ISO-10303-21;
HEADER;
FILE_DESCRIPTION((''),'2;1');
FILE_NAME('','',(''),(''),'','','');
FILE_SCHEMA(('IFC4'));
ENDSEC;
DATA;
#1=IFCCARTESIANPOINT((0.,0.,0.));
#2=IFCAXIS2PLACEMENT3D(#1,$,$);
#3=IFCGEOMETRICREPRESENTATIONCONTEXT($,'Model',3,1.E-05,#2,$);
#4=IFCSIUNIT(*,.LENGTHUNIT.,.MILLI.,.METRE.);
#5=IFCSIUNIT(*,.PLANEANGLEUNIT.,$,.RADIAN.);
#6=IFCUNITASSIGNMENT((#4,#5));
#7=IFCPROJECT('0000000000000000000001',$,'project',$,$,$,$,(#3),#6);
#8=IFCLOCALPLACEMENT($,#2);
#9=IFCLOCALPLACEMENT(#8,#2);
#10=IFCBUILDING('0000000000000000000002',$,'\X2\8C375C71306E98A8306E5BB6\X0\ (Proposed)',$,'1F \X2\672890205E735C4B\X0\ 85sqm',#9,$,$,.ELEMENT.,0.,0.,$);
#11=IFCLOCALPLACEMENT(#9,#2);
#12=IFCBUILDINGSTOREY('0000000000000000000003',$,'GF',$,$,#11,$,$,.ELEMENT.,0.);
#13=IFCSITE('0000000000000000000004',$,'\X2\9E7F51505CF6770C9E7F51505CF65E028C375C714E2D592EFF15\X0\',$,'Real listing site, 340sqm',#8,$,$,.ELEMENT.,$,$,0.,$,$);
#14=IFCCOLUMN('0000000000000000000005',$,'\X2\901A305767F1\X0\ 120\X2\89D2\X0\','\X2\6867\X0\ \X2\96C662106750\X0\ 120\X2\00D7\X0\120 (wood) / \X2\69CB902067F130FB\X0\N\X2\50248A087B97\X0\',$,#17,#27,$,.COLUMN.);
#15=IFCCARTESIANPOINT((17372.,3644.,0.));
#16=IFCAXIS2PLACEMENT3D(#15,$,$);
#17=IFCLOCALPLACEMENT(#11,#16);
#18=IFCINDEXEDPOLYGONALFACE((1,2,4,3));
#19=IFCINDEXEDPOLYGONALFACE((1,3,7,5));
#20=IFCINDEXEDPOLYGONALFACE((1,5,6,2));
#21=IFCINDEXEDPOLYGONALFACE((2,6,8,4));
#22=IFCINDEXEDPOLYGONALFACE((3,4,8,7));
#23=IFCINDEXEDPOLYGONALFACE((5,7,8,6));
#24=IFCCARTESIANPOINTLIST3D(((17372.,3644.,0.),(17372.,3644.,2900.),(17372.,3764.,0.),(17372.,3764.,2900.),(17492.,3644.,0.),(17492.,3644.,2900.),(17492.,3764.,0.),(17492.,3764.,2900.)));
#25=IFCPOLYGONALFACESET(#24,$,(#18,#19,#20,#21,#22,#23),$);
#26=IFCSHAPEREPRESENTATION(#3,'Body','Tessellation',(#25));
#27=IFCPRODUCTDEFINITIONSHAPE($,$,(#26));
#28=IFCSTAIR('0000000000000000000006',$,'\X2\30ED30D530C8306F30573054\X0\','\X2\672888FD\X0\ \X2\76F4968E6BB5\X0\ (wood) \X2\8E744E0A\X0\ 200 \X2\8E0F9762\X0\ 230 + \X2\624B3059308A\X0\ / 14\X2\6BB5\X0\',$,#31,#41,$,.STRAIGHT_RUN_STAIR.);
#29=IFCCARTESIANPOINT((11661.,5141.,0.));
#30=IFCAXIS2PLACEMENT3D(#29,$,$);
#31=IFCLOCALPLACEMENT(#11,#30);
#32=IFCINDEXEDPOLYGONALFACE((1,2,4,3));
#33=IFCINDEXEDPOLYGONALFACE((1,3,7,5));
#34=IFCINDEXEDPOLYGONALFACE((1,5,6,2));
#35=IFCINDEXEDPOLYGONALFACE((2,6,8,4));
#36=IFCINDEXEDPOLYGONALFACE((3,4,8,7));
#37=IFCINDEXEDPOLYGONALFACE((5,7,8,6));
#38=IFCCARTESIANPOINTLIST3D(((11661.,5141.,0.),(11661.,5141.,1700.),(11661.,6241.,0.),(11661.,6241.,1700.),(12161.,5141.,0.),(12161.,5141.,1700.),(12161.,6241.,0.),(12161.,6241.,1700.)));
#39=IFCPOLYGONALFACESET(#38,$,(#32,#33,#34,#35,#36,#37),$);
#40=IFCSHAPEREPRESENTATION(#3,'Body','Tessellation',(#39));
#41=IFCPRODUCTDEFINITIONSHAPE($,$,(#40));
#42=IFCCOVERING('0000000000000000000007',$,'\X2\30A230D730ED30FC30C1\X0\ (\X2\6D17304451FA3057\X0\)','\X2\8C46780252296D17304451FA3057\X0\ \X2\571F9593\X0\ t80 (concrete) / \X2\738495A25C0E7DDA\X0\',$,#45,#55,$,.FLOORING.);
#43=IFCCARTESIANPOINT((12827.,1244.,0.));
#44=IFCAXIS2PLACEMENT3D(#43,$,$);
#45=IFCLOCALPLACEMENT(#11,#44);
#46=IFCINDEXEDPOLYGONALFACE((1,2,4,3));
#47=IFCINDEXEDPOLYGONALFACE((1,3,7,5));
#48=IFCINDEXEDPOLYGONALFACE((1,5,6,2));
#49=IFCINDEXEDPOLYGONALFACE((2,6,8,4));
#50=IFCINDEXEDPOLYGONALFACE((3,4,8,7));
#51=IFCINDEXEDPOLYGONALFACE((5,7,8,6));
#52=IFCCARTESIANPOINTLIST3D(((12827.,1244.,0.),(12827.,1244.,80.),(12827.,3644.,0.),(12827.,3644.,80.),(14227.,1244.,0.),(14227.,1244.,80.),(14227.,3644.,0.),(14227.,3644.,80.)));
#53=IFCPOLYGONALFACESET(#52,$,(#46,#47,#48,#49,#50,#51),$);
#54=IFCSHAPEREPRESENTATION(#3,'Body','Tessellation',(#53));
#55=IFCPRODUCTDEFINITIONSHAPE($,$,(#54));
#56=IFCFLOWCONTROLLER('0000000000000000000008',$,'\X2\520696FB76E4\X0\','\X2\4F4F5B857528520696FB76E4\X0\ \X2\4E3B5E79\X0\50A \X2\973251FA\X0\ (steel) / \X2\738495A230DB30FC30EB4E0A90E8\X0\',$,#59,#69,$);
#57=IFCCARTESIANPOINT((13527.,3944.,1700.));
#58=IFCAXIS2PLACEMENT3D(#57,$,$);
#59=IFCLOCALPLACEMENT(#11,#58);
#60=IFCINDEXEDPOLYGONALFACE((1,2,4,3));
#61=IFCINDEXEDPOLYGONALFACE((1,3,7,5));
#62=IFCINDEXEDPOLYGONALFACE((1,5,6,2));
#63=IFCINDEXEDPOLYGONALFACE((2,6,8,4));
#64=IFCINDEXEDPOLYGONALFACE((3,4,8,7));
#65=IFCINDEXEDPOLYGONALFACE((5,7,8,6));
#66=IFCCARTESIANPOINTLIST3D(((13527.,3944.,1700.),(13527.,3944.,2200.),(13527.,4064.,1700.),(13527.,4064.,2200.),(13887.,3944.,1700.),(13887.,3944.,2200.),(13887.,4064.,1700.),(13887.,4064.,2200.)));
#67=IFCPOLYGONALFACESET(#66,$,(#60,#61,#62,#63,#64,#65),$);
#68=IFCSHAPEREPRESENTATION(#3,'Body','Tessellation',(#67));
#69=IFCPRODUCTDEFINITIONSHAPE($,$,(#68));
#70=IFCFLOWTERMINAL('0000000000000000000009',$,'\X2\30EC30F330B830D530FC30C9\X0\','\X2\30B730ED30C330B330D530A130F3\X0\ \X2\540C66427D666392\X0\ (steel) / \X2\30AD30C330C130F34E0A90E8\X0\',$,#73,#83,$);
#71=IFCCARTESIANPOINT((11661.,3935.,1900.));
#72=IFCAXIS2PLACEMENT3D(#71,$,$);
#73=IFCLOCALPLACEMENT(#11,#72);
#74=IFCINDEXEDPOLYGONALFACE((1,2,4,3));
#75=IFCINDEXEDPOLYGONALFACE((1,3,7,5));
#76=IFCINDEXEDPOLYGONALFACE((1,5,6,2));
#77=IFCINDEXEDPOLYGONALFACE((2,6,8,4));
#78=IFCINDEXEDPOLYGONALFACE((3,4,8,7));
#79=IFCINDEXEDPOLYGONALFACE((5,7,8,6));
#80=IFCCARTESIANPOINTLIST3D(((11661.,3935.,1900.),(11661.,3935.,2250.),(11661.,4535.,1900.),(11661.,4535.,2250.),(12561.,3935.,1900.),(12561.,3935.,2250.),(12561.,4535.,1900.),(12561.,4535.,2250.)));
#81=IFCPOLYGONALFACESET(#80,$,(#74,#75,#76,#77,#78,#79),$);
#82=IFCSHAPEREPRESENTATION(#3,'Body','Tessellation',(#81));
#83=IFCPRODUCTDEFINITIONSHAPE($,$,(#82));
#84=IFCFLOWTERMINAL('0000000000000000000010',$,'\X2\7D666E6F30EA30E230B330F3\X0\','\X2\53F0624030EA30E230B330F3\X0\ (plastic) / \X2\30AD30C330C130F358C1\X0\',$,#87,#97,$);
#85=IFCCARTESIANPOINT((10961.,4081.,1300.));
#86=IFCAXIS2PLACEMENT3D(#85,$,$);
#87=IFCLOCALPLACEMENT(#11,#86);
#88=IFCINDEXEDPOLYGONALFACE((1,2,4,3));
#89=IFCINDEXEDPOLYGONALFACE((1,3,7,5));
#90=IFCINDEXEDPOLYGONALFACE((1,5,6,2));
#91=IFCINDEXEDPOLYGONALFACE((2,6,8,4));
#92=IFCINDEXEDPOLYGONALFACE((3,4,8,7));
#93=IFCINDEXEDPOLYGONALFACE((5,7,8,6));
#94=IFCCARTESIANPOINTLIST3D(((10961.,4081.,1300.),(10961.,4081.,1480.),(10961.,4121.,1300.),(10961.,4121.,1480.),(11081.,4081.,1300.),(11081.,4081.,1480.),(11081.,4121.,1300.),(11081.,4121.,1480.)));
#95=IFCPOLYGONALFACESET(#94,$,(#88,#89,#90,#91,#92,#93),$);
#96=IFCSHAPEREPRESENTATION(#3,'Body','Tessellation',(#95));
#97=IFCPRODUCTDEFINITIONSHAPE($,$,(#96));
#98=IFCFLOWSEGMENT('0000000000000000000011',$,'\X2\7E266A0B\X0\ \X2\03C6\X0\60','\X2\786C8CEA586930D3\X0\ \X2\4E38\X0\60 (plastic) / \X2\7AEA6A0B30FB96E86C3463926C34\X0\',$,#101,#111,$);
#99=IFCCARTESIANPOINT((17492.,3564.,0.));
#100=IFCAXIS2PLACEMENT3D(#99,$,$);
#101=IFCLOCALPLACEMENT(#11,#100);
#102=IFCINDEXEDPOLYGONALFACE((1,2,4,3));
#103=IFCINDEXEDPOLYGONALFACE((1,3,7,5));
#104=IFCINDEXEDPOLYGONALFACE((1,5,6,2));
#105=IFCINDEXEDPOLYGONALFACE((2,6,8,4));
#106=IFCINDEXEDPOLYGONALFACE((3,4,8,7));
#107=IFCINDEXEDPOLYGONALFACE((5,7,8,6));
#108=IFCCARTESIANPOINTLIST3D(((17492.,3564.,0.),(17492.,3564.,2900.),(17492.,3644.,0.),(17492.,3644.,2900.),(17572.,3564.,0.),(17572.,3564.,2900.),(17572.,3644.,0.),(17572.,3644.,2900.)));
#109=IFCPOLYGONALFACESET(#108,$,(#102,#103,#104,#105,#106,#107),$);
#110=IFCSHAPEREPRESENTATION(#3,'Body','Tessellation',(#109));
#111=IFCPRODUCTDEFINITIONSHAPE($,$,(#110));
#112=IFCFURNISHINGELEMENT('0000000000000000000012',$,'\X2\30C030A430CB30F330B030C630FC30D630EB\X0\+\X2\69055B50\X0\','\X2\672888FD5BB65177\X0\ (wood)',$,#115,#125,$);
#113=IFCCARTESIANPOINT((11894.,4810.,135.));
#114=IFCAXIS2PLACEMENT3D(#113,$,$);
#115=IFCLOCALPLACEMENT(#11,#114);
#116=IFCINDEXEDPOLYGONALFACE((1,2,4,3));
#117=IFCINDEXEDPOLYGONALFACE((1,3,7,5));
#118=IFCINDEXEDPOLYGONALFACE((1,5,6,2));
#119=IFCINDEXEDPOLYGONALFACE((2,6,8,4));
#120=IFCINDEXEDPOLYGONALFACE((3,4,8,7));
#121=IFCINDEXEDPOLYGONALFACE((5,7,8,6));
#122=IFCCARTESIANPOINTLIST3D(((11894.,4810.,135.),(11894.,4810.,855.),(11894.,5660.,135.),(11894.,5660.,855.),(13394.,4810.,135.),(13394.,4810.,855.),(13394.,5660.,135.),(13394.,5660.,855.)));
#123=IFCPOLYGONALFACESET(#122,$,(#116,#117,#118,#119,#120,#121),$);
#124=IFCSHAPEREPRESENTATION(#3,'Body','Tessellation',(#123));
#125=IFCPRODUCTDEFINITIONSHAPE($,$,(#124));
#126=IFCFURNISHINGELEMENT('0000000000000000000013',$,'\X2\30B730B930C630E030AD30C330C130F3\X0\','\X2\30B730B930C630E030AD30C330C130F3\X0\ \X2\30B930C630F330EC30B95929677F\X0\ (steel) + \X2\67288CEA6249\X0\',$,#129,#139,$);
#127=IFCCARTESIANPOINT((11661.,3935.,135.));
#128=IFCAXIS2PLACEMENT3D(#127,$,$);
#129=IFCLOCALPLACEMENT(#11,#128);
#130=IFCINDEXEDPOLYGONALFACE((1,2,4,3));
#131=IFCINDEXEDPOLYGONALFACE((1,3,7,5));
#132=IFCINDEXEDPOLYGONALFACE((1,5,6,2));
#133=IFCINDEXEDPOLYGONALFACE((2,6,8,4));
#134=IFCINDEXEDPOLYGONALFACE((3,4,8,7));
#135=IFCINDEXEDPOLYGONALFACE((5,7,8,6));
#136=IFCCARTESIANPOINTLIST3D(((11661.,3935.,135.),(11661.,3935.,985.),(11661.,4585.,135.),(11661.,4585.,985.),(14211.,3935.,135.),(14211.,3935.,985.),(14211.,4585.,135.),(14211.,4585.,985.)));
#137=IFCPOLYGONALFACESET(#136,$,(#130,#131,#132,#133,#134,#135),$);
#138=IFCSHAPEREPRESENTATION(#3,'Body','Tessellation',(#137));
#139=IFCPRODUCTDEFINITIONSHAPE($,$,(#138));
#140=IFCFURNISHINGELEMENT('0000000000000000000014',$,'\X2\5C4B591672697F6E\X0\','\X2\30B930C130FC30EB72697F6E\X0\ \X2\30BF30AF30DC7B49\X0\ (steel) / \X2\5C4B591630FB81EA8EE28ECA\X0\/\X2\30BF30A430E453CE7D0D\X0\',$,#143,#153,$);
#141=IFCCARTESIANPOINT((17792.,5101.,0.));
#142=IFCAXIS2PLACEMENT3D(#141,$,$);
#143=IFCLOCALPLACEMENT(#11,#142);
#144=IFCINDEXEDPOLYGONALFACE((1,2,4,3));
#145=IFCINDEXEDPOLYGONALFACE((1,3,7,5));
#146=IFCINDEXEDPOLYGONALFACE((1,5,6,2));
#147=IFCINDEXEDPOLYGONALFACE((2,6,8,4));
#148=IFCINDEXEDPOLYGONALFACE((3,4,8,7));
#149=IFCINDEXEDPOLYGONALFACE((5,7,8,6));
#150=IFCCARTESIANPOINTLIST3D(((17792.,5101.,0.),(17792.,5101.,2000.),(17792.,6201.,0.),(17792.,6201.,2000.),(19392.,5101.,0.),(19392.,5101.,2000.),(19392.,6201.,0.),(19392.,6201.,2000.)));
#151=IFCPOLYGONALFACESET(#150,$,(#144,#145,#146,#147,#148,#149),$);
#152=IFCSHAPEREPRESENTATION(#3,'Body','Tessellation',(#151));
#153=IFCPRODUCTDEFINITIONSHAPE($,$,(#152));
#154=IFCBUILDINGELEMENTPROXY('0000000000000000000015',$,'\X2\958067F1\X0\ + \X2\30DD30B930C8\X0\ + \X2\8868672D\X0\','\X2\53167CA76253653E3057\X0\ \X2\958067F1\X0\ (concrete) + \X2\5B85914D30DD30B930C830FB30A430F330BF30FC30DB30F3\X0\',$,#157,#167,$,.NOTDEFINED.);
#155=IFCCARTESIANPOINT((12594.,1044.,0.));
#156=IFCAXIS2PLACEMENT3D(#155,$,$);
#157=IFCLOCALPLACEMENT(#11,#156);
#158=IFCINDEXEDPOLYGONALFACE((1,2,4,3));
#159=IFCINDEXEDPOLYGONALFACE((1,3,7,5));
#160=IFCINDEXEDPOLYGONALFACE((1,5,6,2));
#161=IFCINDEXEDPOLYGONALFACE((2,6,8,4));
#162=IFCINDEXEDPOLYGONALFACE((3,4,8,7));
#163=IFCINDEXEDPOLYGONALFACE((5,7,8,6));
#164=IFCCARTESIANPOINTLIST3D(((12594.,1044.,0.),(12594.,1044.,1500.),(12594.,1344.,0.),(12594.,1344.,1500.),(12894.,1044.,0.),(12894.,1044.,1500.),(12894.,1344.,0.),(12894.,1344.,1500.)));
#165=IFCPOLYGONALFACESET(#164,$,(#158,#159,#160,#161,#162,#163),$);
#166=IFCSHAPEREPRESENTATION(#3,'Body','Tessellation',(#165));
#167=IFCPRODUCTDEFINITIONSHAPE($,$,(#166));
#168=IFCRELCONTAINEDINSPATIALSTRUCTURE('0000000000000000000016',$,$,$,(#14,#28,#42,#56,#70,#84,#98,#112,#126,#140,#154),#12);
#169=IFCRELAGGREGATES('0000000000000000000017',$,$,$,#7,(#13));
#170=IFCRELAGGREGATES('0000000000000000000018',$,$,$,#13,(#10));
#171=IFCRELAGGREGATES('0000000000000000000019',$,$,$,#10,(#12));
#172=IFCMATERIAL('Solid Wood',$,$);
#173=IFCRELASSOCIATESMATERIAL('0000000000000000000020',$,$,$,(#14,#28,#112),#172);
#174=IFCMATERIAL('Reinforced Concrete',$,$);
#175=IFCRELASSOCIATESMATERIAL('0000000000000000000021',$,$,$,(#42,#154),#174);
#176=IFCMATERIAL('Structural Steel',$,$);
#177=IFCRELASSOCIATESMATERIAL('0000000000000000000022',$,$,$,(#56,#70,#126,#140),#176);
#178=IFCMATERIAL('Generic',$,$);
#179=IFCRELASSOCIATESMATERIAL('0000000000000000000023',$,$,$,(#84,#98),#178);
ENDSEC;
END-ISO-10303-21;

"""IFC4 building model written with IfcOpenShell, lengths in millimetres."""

from ifc_helpers import new_model, si_unit, frame, frame_2d, origin, place, context, project, spatial, rectangle, extrude, material, element, save


model = new_model("IFC4")

# Units and contexts
model_context = context("Model", 3, precision=1e-05, world=origin())
ifc_project = project(units=[si_unit("LENGTHUNIT", "METRE", prefix="MILLI"), si_unit("PLANEANGLEUNIT", "RADIAN")], contexts=[model_context])

# Site, building, storey
site_placement = place(None, origin())
site = spatial("IfcSite", under=ifc_project, at=site_placement, Name="鹿児島県鹿児島市谷山中央５", ObjectType="Real listing site, 340sqm", CompositionType="ELEMENT", RefElevation=0.0)
building_placement = place(site_placement, origin())
building = spatial("IfcBuilding", under=site, at=building_placement, Name="谷山の風の家 (Proposed)", ObjectType="1F 木造平屋 85sqm", CompositionType="ELEMENT", ElevationOfRefHeight=0.0, ElevationOfTerrain=0.0)
storey_placement = place(building_placement, origin())
storey = spatial("IfcBuildingStorey", under=building, at=storey_placement, Name="GF", CompositionType="ELEMENT", Elevation=0.0)

# Column
ifc_material_1 = material(Name="Solid Wood")
column_1_placement = place(storey_placement, frame((17372.0, 3644.0, 0.0)))
element("IfcColumn", 1, at=column_1_placement, inside=storey, material=ifc_material_1, Name="通し柱 120角", Description="桧 集成材 120×120 (wood) / 構造柱・N値計算", PredefinedType="COLUMN", context=model_context, shape_type="SweptSolid", body=[
    extrude(rectangle(XDim=120.0, YDim=120.0, at=frame_2d((60.0, 60.0))), frame((17372.0, 3644.0, 0.0)), (0.0, 0.0, 1.0), 2900.0),
])

# Stair
stair_placement = place(storey_placement, frame((11661.0, 5141.0, 0.0)))
element("IfcStair", 2, at=stair_placement, inside=storey, material=ifc_material_1, Name="ロフトはしご", Description="木製 直階段 (wood) 蹴上 200 踏面 230 + 手すり / 14段", PredefinedType="STRAIGHT_RUN_STAIR", context=model_context, shape_type="SweptSolid", body=[
    extrude(rectangle(XDim=500.0, YDim=1100.0, at=frame_2d((250.0, 550.0))), frame((11661.0, 5141.0, 0.0)), (0.0, 0.0, 1.0), 1700.0),
])

# Covering
ifc_material_2 = material(Name="Reinforced Concrete")
covering_placement = place(storey_placement, frame((12827.0, 1244.0, 0.0)))
element("IfcCovering", 3, at=covering_placement, inside=storey, material=ifc_material_2, Name="アプローチ (洗い出し)", Description="豆砂利洗い出し 土間 t80 (concrete) / 玄関導線", PredefinedType="FLOORING", context=model_context, shape_type="SweptSolid", body=[
    extrude(rectangle(XDim=1400.0, YDim=2400.0, at=frame_2d((700.0, 1200.0))), frame((12827.0, 1244.0, 0.0)), (0.0, 0.0, 1.0), 80.0),
])

# Flow controller
ifc_material_3 = material(Name="Structural Steel")
flow_controller_placement = place(storey_placement, frame((13527.0, 3944.0, 1700.0)))
element("IfcFlowController", 4, at=flow_controller_placement, inside=storey, material=ifc_material_3, Name="分電盤", Description="住宅用分電盤 主幹50A 露出 (steel) / 玄関ホール上部", context=model_context, shape_type="SweptSolid", body=[
    extrude(rectangle(XDim=360.0, YDim=120.0, at=frame_2d((180.0, 60.0))), frame((13527.0, 3944.0, 1700.0)), (0.0, 0.0, 1.0), 500.0),
])

# Flow terminals
flow_terminal_1_placement = place(storey_placement, frame((11661.0, 3935.0, 1900.0)))
element("IfcFlowTerminal", 5, at=flow_terminal_1_placement, inside=storey, material=ifc_material_3, Name="レンジフード", Description="シロッコファン 同時給排 (steel) / キッチン上部", context=model_context, shape_type="SweptSolid", body=[
    extrude(rectangle(XDim=900.0, YDim=600.0, at=frame_2d((450.0, 300.0))), frame((11661.0, 3935.0, 1900.0)), (0.0, 0.0, 1.0), 350.0),
])
ifc_material_4 = material(Name="Generic")
flow_terminal_2_placement = place(storey_placement, frame((10961.0, 4081.0, 1300.0)))
element("IfcFlowTerminal", 6, at=flow_terminal_2_placement, inside=storey, material=ifc_material_4, Name="給湯リモコン", Description="台所リモコン (plastic) / キッチン壁", context=model_context, shape_type="SweptSolid", body=[
    extrude(rectangle(XDim=120.0, YDim=40.0, at=frame_2d((60.0, 20.0))), frame((10961.0, 4081.0, 1300.0)), (0.0, 0.0, 1.0), 180.0),
])

# Flow segment
flow_segment_placement = place(storey_placement, frame((17492.0, 3564.0, 0.0)))
element("IfcFlowSegment", 7, at=flow_segment_placement, inside=storey, material=ifc_material_4, Name="縦樋 φ60", Description="硬質塩ビ 丸60 (plastic) / 竪樋・雨水排水", context=model_context, shape_type="SweptSolid", body=[
    extrude(rectangle(XDim=80.0, YDim=80.0, at=frame_2d((40.0, 40.0))), frame((17492.0, 3564.0, 0.0)), (0.0, 0.0, 1.0), 2900.0),
])

# Furnishing elements
furnishing_1_placement = place(storey_placement, frame((11894.0, 4810.0, 135.0)))
element("IfcFurnishingElement", 8, at=furnishing_1_placement, inside=storey, material=ifc_material_1, Name="ダイニングテーブル+椅子", Description="木製家具 (wood)", context=model_context, shape_type="SweptSolid", body=[
    extrude(rectangle(XDim=1500.0, YDim=850.0, at=frame_2d((750.0, 425.0))), frame((11894.0, 4810.0, 135.0)), (0.0, 0.0, 1.0), 720.0),
])
furnishing_2_placement = place(storey_placement, frame((11661.0, 3935.0, 135.0)))
element("IfcFurnishingElement", 9, at=furnishing_2_placement, inside=storey, material=ifc_material_3, Name="システムキッチン", Description="システムキッチン ステンレス天板 (steel) + 木質扉", context=model_context, shape_type="SweptSolid", body=[
    extrude(rectangle(XDim=2550.0, YDim=650.0, at=frame_2d((1275.0, 325.0))), frame((11661.0, 3935.0, 135.0)), (0.0, 0.0, 1.0), 850.0),
])
furnishing_3_placement = place(storey_placement, frame((17792.0, 5101.0, 0.0)))
element("IfcFurnishingElement", 10, at=furnishing_3_placement, inside=storey, material=ifc_material_3, Name="屋外物置", Description="スチール物置 タクボ等 (steel) / 屋外・自転車/タイヤ収納", context=model_context, shape_type="SweptSolid", body=[
    extrude(rectangle(XDim=1600.0, YDim=1100.0, at=frame_2d((800.0, 550.0))), frame((17792.0, 5101.0, 0.0)), (0.0, 0.0, 1.0), 2000.0),
])

# Building element proxy
proxy_placement = place(storey_placement, frame((12594.0, 1044.0, 0.0)))
element("IfcBuildingElementProxy", 11, at=proxy_placement, inside=storey, material=ifc_material_2, Name="門柱 + ポスト + 表札", Description="化粧打放し 門柱 (concrete) + 宅配ポスト・インターホン", PredefinedType="NOTDEFINED", context=model_context, shape_type="SweptSolid", body=[
    extrude(rectangle(XDim=300.0, YDim=300.0, at=frame_2d((150.0, 150.0))), frame((12594.0, 1044.0, 0.0)), (0.0, 0.0, 1.0), 1500.0),
])

save(model, "model.ifc")
